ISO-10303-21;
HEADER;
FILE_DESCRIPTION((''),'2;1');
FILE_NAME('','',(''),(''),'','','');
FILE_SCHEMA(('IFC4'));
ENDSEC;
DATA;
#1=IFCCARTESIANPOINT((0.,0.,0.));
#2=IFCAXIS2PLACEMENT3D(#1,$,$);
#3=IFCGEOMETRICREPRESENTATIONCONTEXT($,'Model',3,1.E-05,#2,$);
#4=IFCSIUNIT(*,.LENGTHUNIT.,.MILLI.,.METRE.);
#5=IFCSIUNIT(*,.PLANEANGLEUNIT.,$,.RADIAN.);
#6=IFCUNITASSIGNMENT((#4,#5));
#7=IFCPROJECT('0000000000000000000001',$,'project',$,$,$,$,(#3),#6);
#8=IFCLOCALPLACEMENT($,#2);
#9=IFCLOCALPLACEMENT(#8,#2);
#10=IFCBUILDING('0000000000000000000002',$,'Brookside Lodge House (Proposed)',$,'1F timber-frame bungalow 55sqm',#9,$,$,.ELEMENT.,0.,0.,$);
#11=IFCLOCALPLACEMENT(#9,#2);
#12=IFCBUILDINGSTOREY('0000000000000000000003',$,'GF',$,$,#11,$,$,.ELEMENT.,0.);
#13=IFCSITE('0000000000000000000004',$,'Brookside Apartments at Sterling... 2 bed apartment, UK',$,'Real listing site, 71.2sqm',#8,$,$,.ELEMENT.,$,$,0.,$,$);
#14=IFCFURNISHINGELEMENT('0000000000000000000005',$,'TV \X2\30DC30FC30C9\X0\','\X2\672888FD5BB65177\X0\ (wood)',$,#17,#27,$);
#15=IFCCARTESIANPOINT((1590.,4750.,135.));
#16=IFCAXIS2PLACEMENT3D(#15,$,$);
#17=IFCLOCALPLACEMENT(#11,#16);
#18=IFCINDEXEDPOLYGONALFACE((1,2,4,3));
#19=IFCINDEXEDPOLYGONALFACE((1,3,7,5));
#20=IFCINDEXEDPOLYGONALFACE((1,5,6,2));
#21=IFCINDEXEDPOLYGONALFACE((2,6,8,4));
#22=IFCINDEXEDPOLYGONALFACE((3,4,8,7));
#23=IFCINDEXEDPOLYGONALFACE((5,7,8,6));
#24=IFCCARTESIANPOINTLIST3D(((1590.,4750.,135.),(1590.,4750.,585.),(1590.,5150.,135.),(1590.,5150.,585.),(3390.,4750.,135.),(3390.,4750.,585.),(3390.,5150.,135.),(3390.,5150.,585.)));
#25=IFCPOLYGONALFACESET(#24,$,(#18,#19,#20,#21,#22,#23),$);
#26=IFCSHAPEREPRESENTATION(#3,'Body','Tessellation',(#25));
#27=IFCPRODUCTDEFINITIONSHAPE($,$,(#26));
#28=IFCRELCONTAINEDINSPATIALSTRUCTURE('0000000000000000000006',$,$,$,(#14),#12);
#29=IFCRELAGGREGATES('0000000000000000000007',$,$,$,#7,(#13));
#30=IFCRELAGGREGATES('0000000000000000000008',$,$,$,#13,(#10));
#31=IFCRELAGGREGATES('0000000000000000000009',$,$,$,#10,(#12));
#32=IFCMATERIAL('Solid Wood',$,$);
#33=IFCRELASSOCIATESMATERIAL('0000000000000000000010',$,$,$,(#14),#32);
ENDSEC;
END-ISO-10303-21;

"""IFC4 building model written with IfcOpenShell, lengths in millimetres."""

from ifc_helpers import new_model, si_unit, frame, frame_2d, origin, place, context, project, spatial, rectangle, extrude, material, element, save


model = new_model("IFC4")

# Units and contexts
model_context = context("Model", 3, precision=1e-05, world=origin())
ifc_project = project(units=[si_unit("LENGTHUNIT", "METRE", prefix="MILLI"), si_unit("PLANEANGLEUNIT", "RADIAN")], contexts=[model_context])

# Site, building, storey
site_placement = place(None, origin())
site = spatial("IfcSite", under=ifc_project, at=site_placement, Name="Brookside Apartments at Sterling... 2 bed apartment, UK", ObjectType="Real listing site, 71.2sqm", CompositionType="ELEMENT", RefElevation=0.0)
building_placement = place(site_placement, origin())
building = spatial("IfcBuilding", under=site, at=building_placement, Name="Brookside Lodge House (Proposed)", ObjectType="1F timber-frame bungalow 55sqm", CompositionType="ELEMENT", ElevationOfRefHeight=0.0, ElevationOfTerrain=0.0)
storey_placement = place(building_placement, origin())
storey = spatial("IfcBuildingStorey", under=building, at=storey_placement, Name="GF", CompositionType="ELEMENT", Elevation=0.0)

# Shared definitions
ifc_material_1 = material(Name="Solid Wood")

# Furnishing element
furnishing_1_placement = place(storey_placement, frame((1590.0, 4750.0, 135.0)))
element("IfcFurnishingElement", 1, at=furnishing_1_placement, inside=storey, material=ifc_material_1, Name="TV ボード", Description="木製家具 (wood)", context=model_context, shape_type="SweptSolid", body=[
    extrude(rectangle(XDim=1800.0, YDim=400.0, at=frame_2d((900.0, 200.0))), frame((1590.0, 4750.0, 135.0)), (0.0, 0.0, 1.0), 450.0),
])

save(model, "model.ifc")
